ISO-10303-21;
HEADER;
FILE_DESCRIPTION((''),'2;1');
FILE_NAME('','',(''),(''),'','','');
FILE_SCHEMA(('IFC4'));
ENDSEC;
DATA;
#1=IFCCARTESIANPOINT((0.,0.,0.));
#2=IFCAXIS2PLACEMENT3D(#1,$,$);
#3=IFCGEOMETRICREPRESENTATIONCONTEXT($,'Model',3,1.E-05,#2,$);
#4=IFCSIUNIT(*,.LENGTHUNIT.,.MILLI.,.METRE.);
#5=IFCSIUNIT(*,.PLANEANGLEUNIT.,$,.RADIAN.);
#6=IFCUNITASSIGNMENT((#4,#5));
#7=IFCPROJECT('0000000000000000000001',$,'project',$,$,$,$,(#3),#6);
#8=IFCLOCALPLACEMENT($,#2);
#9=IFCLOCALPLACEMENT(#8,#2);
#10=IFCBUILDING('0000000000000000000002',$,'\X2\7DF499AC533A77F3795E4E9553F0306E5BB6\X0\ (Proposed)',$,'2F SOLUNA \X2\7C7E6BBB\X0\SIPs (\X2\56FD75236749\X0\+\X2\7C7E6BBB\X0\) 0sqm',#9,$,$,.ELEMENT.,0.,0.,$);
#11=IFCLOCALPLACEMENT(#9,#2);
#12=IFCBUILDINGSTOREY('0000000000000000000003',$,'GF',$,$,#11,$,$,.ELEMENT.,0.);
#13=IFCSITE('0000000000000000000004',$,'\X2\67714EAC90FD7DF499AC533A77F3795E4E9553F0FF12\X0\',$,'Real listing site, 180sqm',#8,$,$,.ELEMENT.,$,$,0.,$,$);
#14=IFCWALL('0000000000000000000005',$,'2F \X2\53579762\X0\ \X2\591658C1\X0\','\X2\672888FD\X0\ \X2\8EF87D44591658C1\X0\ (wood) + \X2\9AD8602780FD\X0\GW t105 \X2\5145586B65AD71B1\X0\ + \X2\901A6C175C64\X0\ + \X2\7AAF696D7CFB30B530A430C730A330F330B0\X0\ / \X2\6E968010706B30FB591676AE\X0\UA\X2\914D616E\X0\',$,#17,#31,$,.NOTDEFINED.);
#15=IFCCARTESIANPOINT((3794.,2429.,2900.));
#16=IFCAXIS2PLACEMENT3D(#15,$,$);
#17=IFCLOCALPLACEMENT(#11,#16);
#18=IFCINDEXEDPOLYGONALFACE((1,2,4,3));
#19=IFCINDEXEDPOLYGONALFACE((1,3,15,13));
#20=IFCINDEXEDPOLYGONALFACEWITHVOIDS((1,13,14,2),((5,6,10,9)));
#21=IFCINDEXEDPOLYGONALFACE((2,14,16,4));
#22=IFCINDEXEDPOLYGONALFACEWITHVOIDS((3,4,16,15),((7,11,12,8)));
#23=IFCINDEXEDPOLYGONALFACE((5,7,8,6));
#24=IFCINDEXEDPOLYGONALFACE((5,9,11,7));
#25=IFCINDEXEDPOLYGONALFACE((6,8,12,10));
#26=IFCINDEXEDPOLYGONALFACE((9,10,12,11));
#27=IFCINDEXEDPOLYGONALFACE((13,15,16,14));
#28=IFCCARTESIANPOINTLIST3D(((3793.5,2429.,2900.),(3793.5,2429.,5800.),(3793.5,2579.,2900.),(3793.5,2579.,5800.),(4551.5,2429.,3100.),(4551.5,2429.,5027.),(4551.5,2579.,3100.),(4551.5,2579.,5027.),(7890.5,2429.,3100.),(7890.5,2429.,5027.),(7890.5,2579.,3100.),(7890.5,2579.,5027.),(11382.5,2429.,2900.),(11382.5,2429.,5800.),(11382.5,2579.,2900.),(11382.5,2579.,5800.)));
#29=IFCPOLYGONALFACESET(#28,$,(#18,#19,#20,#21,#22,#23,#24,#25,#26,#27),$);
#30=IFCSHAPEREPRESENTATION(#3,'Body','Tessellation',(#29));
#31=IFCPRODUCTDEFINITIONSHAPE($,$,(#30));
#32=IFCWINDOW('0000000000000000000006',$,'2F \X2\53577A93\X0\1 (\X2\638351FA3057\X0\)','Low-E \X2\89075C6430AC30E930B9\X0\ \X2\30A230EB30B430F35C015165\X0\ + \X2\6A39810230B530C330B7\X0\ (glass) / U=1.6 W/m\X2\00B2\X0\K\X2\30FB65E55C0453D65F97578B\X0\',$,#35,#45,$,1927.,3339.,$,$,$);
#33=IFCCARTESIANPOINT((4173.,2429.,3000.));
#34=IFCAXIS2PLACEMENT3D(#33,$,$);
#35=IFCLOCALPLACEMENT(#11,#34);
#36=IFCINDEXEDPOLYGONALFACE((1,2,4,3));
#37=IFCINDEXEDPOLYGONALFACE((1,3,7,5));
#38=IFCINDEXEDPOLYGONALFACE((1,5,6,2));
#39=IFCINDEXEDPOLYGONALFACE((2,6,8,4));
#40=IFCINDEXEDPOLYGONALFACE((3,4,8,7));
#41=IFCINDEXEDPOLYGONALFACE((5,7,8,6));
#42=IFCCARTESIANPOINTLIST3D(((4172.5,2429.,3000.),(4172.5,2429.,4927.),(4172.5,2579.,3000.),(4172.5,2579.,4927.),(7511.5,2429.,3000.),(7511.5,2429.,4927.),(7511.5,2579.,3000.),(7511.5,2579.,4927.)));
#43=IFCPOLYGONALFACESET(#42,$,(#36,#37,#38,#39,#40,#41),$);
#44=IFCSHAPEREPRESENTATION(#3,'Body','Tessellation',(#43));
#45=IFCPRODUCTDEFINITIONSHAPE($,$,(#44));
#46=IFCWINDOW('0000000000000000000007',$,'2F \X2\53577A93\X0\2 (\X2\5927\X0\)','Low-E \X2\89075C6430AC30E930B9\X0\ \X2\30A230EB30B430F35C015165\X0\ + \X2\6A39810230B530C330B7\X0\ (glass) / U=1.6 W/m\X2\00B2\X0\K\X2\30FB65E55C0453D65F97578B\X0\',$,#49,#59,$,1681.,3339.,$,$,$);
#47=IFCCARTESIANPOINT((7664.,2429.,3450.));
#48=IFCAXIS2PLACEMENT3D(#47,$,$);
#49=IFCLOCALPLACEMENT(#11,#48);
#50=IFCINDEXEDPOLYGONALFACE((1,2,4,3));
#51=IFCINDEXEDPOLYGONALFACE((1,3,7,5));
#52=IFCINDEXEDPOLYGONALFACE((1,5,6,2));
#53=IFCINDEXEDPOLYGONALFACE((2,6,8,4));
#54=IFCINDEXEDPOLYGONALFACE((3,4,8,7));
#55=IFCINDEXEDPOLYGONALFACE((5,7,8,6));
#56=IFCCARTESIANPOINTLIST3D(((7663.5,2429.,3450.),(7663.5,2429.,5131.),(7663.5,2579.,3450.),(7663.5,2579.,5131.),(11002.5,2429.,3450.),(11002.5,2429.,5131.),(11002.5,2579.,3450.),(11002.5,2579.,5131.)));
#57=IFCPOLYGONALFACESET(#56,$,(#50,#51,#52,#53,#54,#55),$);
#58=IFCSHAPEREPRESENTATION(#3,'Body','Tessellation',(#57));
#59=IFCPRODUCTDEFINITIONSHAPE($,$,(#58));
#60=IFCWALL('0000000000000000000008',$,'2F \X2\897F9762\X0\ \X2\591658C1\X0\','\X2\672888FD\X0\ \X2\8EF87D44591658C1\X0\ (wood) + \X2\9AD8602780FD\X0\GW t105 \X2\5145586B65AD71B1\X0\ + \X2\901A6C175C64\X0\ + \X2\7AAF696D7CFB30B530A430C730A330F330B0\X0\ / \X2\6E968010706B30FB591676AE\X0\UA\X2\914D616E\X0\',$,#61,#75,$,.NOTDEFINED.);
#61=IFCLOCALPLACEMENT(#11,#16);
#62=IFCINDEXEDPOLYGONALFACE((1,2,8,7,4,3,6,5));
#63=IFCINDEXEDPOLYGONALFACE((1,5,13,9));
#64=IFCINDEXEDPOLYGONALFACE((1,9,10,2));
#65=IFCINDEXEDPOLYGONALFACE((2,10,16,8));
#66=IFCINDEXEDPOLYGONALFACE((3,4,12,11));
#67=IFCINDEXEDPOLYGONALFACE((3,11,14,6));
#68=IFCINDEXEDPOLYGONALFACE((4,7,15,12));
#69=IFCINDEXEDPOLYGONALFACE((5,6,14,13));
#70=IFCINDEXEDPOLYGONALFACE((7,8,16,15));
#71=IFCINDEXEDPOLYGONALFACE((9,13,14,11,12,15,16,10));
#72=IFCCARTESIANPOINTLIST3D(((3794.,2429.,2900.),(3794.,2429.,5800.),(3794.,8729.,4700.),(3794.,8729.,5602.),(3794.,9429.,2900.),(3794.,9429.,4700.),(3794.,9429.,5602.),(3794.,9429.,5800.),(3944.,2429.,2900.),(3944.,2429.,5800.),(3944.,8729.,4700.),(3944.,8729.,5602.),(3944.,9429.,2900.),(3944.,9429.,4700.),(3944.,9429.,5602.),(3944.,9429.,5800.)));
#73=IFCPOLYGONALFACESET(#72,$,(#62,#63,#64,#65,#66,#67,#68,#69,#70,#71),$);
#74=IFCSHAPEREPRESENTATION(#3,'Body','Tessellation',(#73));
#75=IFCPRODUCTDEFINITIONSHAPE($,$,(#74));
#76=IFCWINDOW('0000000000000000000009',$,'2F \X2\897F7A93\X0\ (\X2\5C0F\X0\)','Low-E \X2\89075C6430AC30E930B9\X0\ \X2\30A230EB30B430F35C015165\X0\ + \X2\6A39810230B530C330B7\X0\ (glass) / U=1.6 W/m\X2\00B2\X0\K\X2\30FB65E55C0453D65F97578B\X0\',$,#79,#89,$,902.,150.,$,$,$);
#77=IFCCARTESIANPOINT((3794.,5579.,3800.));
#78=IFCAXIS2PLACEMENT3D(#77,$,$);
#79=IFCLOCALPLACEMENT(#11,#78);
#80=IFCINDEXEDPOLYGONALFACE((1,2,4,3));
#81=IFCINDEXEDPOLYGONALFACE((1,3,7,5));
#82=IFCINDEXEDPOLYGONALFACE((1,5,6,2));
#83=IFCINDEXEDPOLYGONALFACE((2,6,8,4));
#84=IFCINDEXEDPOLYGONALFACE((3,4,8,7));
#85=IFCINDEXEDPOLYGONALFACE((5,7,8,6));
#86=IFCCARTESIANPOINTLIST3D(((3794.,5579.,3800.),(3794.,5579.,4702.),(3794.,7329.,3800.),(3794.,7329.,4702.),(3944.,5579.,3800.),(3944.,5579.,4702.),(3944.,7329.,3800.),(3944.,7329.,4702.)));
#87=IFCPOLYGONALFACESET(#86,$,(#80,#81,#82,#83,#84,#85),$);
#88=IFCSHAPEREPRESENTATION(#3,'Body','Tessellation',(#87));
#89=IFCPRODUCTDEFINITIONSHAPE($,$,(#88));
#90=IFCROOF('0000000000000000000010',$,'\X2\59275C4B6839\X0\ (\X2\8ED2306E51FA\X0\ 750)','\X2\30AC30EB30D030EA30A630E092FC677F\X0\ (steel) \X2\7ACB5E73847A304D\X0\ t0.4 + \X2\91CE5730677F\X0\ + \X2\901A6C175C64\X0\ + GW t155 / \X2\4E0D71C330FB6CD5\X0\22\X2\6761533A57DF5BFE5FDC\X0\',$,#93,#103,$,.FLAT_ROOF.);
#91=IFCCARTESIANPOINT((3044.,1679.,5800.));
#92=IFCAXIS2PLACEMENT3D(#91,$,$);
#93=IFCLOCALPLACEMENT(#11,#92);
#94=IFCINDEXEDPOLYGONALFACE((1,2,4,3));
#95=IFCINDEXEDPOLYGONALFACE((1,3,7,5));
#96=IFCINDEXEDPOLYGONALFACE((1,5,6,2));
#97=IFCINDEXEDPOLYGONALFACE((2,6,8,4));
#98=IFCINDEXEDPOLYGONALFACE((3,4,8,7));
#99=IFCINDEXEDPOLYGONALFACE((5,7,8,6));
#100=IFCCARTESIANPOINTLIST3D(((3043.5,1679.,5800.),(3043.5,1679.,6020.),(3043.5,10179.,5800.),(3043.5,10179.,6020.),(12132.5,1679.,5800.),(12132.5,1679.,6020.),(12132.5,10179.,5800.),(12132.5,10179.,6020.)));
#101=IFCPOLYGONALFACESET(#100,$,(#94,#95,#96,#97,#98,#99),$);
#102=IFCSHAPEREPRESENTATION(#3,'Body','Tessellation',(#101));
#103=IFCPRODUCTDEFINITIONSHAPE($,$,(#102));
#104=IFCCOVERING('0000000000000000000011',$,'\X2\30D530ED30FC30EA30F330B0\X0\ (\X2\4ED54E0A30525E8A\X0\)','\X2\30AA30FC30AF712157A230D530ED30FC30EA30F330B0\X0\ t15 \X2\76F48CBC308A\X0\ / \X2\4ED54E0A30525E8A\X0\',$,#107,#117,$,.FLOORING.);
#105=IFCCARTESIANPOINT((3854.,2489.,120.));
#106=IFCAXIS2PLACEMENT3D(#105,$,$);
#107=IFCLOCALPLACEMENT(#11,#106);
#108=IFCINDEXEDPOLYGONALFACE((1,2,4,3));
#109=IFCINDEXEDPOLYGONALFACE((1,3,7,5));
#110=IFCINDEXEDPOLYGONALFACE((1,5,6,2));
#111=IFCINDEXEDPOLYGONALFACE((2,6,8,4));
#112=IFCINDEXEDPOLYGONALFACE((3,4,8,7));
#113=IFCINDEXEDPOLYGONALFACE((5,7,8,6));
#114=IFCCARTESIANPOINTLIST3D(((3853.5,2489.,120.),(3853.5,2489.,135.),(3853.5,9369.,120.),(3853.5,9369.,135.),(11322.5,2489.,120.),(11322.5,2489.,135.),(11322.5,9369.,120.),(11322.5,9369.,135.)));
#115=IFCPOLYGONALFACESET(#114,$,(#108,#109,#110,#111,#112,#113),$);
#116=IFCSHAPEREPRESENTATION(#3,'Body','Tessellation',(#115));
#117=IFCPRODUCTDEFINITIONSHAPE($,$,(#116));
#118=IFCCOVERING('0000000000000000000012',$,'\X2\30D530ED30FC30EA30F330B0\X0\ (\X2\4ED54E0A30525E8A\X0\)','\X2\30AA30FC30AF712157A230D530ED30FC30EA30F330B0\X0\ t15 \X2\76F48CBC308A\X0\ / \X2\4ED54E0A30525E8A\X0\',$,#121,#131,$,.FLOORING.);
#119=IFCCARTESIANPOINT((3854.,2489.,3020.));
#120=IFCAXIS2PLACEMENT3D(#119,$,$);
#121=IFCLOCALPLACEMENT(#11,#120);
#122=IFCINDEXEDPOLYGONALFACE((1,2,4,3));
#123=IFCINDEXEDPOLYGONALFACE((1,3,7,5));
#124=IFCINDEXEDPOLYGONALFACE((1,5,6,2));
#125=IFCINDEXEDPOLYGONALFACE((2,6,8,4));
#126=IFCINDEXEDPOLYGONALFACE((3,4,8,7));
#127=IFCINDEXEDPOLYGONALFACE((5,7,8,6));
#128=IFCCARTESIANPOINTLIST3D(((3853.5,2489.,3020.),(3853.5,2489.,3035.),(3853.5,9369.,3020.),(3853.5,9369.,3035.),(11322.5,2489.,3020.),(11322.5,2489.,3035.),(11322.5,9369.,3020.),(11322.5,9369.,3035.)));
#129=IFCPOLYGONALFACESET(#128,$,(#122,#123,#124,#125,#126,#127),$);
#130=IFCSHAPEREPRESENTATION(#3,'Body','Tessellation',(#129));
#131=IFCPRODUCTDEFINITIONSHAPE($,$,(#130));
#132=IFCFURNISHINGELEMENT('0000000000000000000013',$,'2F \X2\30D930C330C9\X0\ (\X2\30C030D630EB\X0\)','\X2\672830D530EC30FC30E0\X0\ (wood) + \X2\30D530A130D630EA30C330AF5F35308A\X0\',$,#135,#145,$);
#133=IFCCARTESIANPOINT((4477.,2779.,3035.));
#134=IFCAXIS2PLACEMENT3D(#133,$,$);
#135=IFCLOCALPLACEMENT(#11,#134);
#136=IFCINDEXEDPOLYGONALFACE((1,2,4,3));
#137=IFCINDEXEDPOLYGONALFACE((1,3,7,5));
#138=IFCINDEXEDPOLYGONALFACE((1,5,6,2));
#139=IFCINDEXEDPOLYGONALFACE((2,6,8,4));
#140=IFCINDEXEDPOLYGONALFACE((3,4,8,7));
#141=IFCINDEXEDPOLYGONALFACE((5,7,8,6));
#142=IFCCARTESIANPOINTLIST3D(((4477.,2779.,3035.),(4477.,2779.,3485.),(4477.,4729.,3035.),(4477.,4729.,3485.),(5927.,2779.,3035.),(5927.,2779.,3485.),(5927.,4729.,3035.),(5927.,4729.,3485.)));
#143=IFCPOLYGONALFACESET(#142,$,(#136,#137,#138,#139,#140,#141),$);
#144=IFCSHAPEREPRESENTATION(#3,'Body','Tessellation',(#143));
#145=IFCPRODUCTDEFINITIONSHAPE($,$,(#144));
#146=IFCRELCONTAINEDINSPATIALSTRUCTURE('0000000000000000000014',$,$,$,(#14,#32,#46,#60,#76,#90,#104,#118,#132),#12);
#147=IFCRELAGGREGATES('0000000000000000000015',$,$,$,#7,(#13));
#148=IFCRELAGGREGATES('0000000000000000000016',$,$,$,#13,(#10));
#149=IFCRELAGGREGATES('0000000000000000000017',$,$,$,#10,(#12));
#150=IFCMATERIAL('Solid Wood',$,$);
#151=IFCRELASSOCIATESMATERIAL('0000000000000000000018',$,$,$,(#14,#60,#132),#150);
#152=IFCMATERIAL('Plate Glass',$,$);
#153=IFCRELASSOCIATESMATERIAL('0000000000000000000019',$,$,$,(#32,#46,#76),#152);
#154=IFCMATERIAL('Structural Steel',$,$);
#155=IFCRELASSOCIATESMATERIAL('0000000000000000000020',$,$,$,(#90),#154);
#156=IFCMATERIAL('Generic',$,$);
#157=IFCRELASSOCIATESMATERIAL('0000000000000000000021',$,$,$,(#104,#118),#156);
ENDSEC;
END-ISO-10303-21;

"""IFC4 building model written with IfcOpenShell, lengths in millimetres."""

from ifc_helpers import new_model, si_unit, frame, frame_2d, origin, place, context, project, spatial, rectangle, extrude, material, element, fill, save


model = new_model("IFC4")

# Units and contexts
model_context = context("Model", 3, precision=1e-05, world=origin())
ifc_project = project(units=[si_unit("LENGTHUNIT", "METRE", prefix="MILLI"), si_unit("PLANEANGLEUNIT", "RADIAN")], contexts=[model_context])

# Site, building, storey
site_placement = place(None, origin())
site = spatial("IfcSite", under=ifc_project, at=site_placement, Name="東京都練馬区石神井台２", ObjectType="Real listing site, 180sqm", CompositionType="ELEMENT", RefElevation=0.0)
building_placement = place(site_placement, origin())
building = spatial("IfcBuilding", under=site, at=building_placement, Name="練馬区石神井台の家 (Proposed)", ObjectType="2F SOLUNA 籾殻SIPs (国産杉+籾殻) 0sqm", CompositionType="ELEMENT", ElevationOfRefHeight=0.0, ElevationOfTerrain=0.0)
storey_placement = place(building_placement, origin())
storey = spatial("IfcBuildingStorey", under=building, at=storey_placement, Name="GF", CompositionType="ELEMENT", Elevation=0.0)

# Shared definitions
ifc_material_1 = material(Name="Solid Wood")

# Shared definitions
ifc_material_2 = material(Name="Plate Glass")

# Wall, openings, windows
wall_1_placement = place(storey_placement, frame((3794.0, 2429.0, 2900.0)))
wall_1 = element("IfcWall", 1, at=wall_1_placement, inside=storey, material=ifc_material_1, Name="2F 南面 外壁", Description="木製 軸組外壁 (wood) + 高性能GW t105 充填断熱 + 通気層 + 窯業系サイディング / 準耐火・外皮UA配慮", PredefinedType="NOTDEFINED", context=model_context, shape_type="SweptSolid", body=[
    extrude(rectangle(XDim=7589.0, YDim=150.0, at=frame_2d((3794.0, 75.0))), frame((3794.0, 2429.0, 2900.0)), (0.0, 0.0, 1.0), 2900.0),
])
opening_1_placement = place(storey_placement, frame((4173.0, 2429.0, 3000.0)))
opening_1 = element("IfcOpeningElement", 2, at=opening_1_placement, cuts=wall_1, PredefinedType="NOTDEFINED", context=model_context, shape_type="SweptSolid", body=[
    extrude(rectangle(XDim=3339.0, YDim=150.0, at=frame_2d((1669.0, 75.0))), frame((4173.0, 2429.0, 3000.0)), (0.0, 0.0, 1.0), 1927.0),
])
opening_2_placement = place(storey_placement, frame((7664.0, 2429.0, 3450.0)))
opening_2 = element("IfcOpeningElement", 3, at=opening_2_placement, cuts=wall_1, PredefinedType="NOTDEFINED", context=model_context, shape_type="SweptSolid", body=[
    extrude(rectangle(XDim=3339.0, YDim=150.0, at=frame_2d((1669.0, 75.0))), frame((7664.0, 2429.0, 3450.0)), (0.0, 0.0, 1.0), 1681.0),
])
window_1_placement = place(storey_placement, frame((4173.0, 2429.0, 3000.0)))
window_1 = element("IfcWindow", 4, at=window_1_placement, inside=storey, material=ifc_material_2, Name="2F 南窓1 (掃出し)", Description="Low-E 複層ガラス アルゴン封入 + 樹脂サッシ (glass) / U=1.6 W/m²K・日射取得型", OverallHeight=1927.0, OverallWidth=3339.0, context=model_context, shape_type="SweptSolid", body=[
    extrude(rectangle(XDim=3339.0, YDim=150.0, at=frame_2d((1669.0, 75.0))), frame((4173.0, 2429.0, 3000.0)), (0.0, 0.0, 1.0), 1927.0),
])
fill(opening_1, window_1)
window_2_placement = place(storey_placement, frame((7664.0, 2429.0, 3450.0)))
window_2 = element("IfcWindow", 5, at=window_2_placement, inside=storey, material=ifc_material_2, Name="2F 南窓2 (大)", Description="Low-E 複層ガラス アルゴン封入 + 樹脂サッシ (glass) / U=1.6 W/m²K・日射取得型", OverallHeight=1681.0, OverallWidth=3339.0, context=model_context, shape_type="SweptSolid", body=[
    extrude(rectangle(XDim=3339.0, YDim=150.0, at=frame_2d((1669.0, 75.0))), frame((7664.0, 2429.0, 3450.0)), (0.0, 0.0, 1.0), 1681.0),
])
fill(opening_2, window_2)

# Wall, opening, window
wall_2_placement = place(storey_placement, frame((3794.0, 2429.0, 2900.0)))
wall_2 = element("IfcWall", 6, at=wall_2_placement, inside=storey, material=ifc_material_1, Name="2F 西面 外壁", Description="木製 軸組外壁 (wood) + 高性能GW t105 充填断熱 + 通気層 + 窯業系サイディング / 準耐火・外皮UA配慮", PredefinedType="NOTDEFINED", context=model_context, shape_type="SweptSolid", body=[
    extrude(rectangle(XDim=150.0, YDim=7000.0, at=frame_2d((75.0, 3500.0))), frame((3794.0, 2429.0, 2900.0)), (0.0, 0.0, 1.0), 2900.0),
])
opening_3_placement = place(storey_placement, frame((3794.0, 5579.0, 3800.0)))
opening_3 = element("IfcOpeningElement", 7, at=opening_3_placement, cuts=wall_2, PredefinedType="NOTDEFINED", context=model_context, shape_type="SweptSolid", body=[
    extrude(rectangle(XDim=150.0, YDim=1750.0, at=frame_2d((75.0, 875.0))), frame((3794.0, 5579.0, 3800.0)), (0.0, 0.0, 1.0), 902.0),
])
window_3_placement = place(storey_placement, frame((3794.0, 5579.0, 3800.0)))
window_3 = element("IfcWindow", 8, at=window_3_placement, inside=storey, material=ifc_material_2, Name="2F 西窓 (小)", Description="Low-E 複層ガラス アルゴン封入 + 樹脂サッシ (glass) / U=1.6 W/m²K・日射取得型", OverallHeight=902.0, OverallWidth=150.0, context=model_context, shape_type="SweptSolid", body=[
    extrude(rectangle(XDim=150.0, YDim=1750.0, at=frame_2d((75.0, 875.0))), frame((3794.0, 5579.0, 3800.0)), (0.0, 0.0, 1.0), 902.0),
])
fill(opening_3, window_3)

# Roof
ifc_material_3 = material(Name="Structural Steel")
roof_placement = place(storey_placement, frame((3044.0, 1679.0, 5800.0)))
element("IfcRoof", 9, at=roof_placement, inside=storey, material=ifc_material_3, Name="大屋根 (軒の出 750)", Description="ガルバリウム鋼板 (steel) 立平葺き t0.4 + 野地板 + 通気層 + GW t155 / 不燃・法22条区域対応", PredefinedType="FLAT_ROOF", context=model_context, shape_type="SweptSolid", body=[
    extrude(rectangle(XDim=9089.0, YDim=8500.0, at=frame_2d((4544.0, 4250.0))), frame((3044.0, 1679.0, 5800.0)), (0.0, 0.0, 1.0), 220.0),
])

# Coverings
ifc_material_4 = material(Name="Generic")
covering_1_placement = place(storey_placement, frame((3854.0, 2489.0, 120.0)))
element("IfcCovering", 10, at=covering_1_placement, inside=storey, material=ifc_material_4, Name="フローリング (仕上げ床)", Description="オーク無垢フローリング t15 直貼り / 仕上げ床", PredefinedType="FLOORING", context=model_context, shape_type="SweptSolid", body=[
    extrude(rectangle(XDim=7469.0, YDim=6880.0, at=frame_2d((3734.0, 3440.0))), frame((3854.0, 2489.0, 120.0)), (0.0, 0.0, 1.0), 15.0),
])
covering_2_placement = place(storey_placement, frame((3854.0, 2489.0, 3020.0)))
element("IfcCovering", 11, at=covering_2_placement, inside=storey, material=ifc_material_4, Name="フローリング (仕上げ床)", Description="オーク無垢フローリング t15 直貼り / 仕上げ床", PredefinedType="FLOORING", context=model_context, shape_type="SweptSolid", body=[
    extrude(rectangle(XDim=7469.0, YDim=6880.0, at=frame_2d((3734.0, 3440.0))), frame((3854.0, 2489.0, 3020.0)), (0.0, 0.0, 1.0), 15.0),
])

# Furnishing element
furnishing_placement = place(storey_placement, frame((4477.0, 2779.0, 3035.0)))
element("IfcFurnishingElement", 12, at=furnishing_placement, inside=storey, material=ifc_material_1, Name="2F ベッド (ダブル)", Description="木フレーム (wood) + ファブリック張り", context=model_context, shape_type="SweptSolid", body=[
    extrude(rectangle(XDim=1450.0, YDim=1950.0, at=frame_2d((725.0, 975.0))), frame((4477.0, 2779.0, 3035.0)), (0.0, 0.0, 1.0), 450.0),
])

save(model, "model.ifc")
